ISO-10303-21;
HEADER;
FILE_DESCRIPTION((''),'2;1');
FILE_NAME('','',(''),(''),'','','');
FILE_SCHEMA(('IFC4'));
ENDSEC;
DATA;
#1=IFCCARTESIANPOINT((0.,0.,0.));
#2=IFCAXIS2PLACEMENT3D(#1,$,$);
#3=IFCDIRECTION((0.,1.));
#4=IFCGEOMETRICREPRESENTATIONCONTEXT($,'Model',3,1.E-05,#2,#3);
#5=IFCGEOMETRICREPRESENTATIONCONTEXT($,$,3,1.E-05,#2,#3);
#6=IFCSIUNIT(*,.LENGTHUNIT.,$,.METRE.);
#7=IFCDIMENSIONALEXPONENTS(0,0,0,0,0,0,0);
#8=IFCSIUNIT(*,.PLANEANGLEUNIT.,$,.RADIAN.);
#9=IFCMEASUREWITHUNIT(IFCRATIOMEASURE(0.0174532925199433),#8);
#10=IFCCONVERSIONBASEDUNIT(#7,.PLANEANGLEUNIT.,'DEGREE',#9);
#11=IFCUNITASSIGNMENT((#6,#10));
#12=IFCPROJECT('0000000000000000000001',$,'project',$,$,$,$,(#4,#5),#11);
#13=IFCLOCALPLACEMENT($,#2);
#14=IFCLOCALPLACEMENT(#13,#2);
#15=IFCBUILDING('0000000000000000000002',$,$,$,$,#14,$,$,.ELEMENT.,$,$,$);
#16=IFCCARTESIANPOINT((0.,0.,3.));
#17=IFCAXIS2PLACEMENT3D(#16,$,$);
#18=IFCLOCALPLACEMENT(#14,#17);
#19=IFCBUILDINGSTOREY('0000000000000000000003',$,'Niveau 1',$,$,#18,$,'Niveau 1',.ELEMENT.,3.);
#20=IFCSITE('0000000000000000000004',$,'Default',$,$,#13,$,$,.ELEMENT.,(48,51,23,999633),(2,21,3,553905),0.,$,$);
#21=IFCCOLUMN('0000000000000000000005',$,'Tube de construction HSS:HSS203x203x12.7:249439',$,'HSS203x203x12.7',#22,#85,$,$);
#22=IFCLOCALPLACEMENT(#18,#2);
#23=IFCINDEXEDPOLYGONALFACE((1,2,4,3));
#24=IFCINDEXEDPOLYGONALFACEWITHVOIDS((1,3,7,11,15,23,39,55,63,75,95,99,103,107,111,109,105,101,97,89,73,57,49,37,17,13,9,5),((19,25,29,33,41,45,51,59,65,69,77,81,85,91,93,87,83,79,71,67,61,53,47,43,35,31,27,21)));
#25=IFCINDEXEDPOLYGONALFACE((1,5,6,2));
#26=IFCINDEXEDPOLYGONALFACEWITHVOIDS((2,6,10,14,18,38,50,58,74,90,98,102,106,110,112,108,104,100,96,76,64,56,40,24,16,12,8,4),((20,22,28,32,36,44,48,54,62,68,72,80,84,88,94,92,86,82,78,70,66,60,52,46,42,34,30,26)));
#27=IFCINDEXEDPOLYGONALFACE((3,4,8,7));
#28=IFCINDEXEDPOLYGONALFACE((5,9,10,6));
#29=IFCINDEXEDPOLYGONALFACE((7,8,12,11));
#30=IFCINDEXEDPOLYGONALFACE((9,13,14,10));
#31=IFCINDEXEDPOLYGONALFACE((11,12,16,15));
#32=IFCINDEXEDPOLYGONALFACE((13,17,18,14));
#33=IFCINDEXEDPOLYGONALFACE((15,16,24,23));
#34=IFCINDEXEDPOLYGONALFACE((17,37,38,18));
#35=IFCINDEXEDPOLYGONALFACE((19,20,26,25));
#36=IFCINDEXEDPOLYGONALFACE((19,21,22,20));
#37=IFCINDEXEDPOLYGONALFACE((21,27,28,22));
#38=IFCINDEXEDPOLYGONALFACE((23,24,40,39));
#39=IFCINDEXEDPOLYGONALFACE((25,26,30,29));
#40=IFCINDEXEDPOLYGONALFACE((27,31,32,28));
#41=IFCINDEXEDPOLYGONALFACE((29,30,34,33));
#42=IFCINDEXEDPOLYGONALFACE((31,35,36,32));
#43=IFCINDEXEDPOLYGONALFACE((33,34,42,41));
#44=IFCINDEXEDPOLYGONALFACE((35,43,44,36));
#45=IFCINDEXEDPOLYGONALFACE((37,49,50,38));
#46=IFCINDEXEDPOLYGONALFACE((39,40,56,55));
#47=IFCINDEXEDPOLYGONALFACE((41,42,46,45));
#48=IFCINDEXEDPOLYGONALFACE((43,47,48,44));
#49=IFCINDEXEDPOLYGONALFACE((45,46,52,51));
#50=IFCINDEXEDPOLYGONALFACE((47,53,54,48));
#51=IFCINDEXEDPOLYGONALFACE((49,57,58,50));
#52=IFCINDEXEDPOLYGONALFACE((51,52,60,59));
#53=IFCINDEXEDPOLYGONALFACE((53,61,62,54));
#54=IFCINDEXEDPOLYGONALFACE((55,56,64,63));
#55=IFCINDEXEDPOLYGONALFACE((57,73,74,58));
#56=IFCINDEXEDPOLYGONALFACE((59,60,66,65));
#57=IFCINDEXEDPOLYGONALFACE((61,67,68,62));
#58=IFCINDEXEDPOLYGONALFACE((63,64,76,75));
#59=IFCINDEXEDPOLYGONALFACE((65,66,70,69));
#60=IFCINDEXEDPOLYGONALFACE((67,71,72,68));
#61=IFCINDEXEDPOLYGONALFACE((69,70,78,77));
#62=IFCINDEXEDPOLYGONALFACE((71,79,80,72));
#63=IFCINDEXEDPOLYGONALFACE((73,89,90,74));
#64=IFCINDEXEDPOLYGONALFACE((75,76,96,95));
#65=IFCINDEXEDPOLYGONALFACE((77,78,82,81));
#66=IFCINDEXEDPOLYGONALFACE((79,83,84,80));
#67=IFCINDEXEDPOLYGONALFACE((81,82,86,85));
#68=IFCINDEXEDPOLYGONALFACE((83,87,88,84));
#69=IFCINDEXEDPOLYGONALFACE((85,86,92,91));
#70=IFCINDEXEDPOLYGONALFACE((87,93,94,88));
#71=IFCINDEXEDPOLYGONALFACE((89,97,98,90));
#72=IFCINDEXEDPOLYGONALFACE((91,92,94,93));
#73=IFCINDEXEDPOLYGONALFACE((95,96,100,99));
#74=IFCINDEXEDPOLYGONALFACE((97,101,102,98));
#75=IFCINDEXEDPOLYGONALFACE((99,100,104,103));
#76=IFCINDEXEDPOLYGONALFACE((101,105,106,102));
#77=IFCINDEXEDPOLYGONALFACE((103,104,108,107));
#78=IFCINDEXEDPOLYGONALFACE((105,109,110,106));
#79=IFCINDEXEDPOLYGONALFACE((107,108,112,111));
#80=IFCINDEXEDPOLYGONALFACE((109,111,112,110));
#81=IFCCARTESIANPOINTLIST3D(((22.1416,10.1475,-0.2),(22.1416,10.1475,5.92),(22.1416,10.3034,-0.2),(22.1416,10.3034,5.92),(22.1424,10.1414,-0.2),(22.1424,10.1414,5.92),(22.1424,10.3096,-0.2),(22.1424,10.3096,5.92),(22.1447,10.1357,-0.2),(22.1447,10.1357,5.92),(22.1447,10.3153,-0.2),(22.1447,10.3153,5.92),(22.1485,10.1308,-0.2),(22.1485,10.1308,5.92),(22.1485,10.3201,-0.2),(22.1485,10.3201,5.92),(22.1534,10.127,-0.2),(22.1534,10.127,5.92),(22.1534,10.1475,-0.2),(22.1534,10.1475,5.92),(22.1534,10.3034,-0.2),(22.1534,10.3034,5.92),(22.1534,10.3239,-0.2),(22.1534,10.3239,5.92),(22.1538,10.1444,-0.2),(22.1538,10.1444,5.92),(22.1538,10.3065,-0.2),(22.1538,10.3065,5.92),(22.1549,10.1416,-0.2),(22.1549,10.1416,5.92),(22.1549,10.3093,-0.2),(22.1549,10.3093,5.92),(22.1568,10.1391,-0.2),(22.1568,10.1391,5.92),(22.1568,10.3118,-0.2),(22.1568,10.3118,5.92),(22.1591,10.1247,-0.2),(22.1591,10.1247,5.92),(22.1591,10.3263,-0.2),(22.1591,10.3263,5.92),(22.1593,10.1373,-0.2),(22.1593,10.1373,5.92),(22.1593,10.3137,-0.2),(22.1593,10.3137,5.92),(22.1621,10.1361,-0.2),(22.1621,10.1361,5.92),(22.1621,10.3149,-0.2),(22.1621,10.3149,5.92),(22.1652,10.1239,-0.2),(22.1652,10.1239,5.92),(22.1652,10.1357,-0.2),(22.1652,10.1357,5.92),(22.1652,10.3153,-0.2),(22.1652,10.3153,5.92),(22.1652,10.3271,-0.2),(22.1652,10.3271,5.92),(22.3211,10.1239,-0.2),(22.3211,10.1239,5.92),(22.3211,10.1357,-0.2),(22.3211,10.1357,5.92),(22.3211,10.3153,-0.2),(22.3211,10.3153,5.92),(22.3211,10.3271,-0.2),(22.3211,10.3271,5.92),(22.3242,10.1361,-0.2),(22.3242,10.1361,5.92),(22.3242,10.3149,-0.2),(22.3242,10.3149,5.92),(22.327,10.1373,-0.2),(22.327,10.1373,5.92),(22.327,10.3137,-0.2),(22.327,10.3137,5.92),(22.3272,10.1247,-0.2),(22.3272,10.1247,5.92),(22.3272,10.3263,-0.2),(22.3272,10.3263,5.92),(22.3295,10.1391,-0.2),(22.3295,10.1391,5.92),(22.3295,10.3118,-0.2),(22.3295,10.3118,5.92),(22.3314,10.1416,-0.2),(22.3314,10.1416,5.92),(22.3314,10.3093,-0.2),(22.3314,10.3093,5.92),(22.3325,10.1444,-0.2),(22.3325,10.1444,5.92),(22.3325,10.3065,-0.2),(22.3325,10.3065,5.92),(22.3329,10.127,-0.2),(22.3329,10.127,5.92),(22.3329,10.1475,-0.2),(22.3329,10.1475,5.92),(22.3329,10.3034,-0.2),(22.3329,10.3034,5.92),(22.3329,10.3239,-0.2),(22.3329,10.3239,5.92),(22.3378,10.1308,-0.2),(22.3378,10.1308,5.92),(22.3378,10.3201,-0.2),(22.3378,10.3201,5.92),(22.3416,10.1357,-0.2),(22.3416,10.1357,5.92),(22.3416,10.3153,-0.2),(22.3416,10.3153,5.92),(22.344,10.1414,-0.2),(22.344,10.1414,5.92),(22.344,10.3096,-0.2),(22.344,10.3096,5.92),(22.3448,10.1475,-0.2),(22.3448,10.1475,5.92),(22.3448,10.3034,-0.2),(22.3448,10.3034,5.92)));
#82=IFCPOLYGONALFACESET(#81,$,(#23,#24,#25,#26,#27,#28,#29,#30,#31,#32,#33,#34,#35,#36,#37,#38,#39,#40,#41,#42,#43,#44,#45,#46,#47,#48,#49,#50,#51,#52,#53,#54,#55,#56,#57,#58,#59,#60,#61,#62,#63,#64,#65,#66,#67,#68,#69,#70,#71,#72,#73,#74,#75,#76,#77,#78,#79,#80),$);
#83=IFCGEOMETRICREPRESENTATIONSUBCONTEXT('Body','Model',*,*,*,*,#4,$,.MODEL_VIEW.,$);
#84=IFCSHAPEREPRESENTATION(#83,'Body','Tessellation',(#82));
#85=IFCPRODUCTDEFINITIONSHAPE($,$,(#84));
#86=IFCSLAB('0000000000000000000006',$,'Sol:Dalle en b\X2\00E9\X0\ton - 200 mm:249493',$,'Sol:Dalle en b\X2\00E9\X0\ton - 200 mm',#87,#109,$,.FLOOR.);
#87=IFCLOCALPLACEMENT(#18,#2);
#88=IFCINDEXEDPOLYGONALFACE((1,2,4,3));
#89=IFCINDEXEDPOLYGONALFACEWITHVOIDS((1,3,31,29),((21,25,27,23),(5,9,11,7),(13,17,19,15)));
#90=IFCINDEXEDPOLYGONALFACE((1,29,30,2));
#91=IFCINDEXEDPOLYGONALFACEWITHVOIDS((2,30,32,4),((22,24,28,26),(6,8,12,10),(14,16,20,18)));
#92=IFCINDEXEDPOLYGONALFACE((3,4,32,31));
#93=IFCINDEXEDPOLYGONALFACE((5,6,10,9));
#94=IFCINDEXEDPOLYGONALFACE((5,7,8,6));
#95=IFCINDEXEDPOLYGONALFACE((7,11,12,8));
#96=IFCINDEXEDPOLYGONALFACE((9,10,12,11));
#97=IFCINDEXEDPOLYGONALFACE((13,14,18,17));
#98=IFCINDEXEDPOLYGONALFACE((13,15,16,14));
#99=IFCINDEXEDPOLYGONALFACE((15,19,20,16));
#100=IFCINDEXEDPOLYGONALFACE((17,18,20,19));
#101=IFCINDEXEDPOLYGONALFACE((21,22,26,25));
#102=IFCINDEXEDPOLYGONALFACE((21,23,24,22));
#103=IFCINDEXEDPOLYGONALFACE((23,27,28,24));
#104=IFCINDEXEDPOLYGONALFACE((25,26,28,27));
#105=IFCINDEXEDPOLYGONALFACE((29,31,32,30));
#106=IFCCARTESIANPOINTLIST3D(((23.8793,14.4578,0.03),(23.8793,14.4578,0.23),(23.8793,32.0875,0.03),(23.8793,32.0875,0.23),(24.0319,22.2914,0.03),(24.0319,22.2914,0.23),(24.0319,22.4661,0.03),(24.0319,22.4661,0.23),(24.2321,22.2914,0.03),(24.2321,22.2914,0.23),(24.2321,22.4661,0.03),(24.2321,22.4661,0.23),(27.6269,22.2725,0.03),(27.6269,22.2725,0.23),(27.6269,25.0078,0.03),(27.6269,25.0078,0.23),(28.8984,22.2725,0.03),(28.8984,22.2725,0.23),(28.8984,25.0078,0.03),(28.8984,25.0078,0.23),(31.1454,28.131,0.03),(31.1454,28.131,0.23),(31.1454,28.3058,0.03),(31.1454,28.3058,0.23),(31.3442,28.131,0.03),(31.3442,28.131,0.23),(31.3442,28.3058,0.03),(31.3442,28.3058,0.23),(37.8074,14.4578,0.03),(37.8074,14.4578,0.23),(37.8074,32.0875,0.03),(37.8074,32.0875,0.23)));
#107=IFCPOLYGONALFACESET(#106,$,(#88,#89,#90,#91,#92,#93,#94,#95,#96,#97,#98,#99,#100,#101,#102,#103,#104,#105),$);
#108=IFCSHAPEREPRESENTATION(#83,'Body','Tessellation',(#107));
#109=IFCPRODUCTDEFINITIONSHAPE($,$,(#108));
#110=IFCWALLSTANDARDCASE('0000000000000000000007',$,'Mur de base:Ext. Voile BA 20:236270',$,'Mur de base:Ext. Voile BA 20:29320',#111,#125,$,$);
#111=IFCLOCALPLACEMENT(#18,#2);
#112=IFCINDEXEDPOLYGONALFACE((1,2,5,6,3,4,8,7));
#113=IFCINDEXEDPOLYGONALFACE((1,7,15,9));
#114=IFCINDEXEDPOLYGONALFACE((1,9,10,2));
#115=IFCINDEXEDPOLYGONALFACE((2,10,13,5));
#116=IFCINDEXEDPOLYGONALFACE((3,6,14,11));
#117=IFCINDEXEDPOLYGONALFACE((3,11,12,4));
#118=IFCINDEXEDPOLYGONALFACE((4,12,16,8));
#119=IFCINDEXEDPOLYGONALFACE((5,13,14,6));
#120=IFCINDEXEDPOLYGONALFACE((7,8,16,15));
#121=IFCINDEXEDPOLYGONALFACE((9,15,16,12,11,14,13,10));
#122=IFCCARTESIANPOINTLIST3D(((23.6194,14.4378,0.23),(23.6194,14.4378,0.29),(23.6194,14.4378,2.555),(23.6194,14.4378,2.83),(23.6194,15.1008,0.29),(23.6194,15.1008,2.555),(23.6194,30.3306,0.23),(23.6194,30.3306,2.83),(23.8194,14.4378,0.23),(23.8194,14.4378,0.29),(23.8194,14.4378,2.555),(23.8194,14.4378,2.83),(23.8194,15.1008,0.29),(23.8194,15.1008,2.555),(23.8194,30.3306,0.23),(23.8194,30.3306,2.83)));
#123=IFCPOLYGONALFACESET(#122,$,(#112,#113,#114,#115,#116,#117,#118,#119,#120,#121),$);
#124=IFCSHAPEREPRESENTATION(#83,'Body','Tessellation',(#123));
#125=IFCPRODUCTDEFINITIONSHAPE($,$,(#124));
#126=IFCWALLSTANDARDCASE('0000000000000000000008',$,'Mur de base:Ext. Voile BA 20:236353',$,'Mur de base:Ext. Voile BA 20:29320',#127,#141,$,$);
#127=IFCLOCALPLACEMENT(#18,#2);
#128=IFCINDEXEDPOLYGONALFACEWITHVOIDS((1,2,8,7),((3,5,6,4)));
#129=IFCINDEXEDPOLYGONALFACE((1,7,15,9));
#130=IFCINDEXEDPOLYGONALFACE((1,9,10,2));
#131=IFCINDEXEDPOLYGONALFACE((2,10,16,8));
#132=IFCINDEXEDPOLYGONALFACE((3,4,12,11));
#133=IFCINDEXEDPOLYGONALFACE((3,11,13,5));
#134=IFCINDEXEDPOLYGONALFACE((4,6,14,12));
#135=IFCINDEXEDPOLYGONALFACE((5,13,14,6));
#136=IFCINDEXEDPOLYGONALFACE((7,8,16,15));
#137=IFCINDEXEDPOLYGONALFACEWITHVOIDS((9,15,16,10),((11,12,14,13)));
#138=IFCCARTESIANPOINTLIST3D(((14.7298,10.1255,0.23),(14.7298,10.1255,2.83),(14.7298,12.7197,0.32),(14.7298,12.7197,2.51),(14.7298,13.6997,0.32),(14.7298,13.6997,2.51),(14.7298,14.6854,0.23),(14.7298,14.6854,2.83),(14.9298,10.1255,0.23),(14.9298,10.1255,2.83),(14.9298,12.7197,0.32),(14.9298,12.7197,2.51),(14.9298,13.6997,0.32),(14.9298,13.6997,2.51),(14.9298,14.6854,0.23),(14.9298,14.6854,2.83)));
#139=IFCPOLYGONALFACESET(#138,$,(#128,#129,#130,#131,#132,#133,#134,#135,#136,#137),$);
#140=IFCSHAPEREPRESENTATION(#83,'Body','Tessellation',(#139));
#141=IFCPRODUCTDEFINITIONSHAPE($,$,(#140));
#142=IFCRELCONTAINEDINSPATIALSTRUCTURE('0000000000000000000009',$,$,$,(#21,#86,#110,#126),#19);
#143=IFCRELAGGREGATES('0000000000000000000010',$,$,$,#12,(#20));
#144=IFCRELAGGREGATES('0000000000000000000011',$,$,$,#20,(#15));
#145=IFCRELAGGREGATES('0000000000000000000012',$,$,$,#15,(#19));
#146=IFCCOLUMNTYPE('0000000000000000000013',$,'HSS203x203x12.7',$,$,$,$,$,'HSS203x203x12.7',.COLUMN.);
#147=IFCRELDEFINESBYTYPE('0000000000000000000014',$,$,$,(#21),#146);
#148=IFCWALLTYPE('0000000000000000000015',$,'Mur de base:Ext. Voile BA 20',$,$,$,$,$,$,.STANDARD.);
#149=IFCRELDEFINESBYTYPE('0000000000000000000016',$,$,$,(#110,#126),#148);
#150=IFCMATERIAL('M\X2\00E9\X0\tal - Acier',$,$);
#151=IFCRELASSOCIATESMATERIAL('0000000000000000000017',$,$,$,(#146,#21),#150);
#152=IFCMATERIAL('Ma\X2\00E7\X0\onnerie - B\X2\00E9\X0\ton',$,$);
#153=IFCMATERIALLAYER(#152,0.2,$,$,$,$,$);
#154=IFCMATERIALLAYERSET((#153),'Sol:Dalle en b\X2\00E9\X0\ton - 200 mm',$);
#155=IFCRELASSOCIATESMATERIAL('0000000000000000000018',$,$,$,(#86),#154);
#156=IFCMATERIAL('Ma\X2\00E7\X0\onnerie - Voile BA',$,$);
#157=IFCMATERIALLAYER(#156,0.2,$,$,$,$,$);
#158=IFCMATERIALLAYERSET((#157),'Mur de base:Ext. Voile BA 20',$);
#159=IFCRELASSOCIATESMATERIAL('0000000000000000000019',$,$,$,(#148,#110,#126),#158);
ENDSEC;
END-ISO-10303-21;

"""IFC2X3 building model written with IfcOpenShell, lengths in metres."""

from ifc_helpers import new_model, entity, si_unit, converted_unit, direction, frame, frame_2d, origin, origin_2d_with_axis, place, context, subcontext, project, spatial, polyline, circle_curve, parameter, trimmed, segment, composite_curve, rectangle, outline, extrude, source, transform, mapped, material, layer, layer_set, layer_usage, type_object, type_shapes, element, save


model = new_model("IFC2X3")

# Units and contexts
model_context = context("Model", 3, precision=1e-05, world=origin(), true_north=direction((0.0, 1.0)))
context_of_model = context(None, 3, precision=1e-05, world=origin(), true_north=direction((0.0, 1.0)))
body_context = subcontext(model_context, "Body", "Model", "MODEL_VIEW")
ifc_project = project(units=[si_unit("LENGTHUNIT", "METRE"), converted_unit("PLANEANGLEUNIT", "DEGREE", entity("IfcRatioMeasure", 0.0174532925199433), si_unit("PLANEANGLEUNIT", "RADIAN"), dimensions=[0, 0, 0, 0, 0, 0, 0])], contexts=[model_context, context_of_model])

# Site, building, storey
site_placement = place(None, origin())
site = spatial("IfcSite", under=ifc_project, at=site_placement, Name="Default", CompositionType="ELEMENT", RefLatitude=(48, 51, 23, 999633), RefLongitude=(2, 21, 3, 553905), RefElevation=0.0)
building_placement = place(site_placement, origin())
building = spatial("IfcBuilding", under=site, at=building_placement, CompositionType="ELEMENT")
storey_placement = place(building_placement, frame((0.0, 0.0, 3.0)))
storey = spatial("IfcBuildingStorey", under=building, at=storey_placement, Name="Niveau 1", LongName="Niveau 1", CompositionType="ELEMENT", Elevation=3.0)

# Column
ifc_material_1 = material(Name="Métal - Acier")
column_type = type_object("IfcColumnType", Name="HSS203x203x12.7", ElementType="HSS203x203x12.7", PredefinedType="COLUMN", material=ifc_material_1)
shared_shape = source(origin(), body_context, "Body", "SweptSolid", [
    extrude(outline(composite_curve([segment(polyline([(-0.078, -0.1016), (0.078, -0.1016)]), True, "CONTINUOUS"), segment(trimmed(circle_curve(frame_2d((0.078, -0.078), x_axis=(-1.0, 0.0)), 0.0236), [parameter(90.0)], [parameter(180.0)], True, "PARAMETER"), True, "CONTINUOUS"), segment(polyline([(0.1016, -0.078), (0.1016, 0.078)]), True, "CONTINUOUS"), segment(trimmed(circle_curve(frame_2d((0.078, 0.078), x_axis=(-1.0, 0.0)), 0.0236), [parameter(180.0)], [parameter(270.0)], True, "PARAMETER"), True, "CONTINUOUS"), segment(polyline([(0.078, 0.1016), (-0.078, 0.1016)]), True, "CONTINUOUS"), segment(trimmed(circle_curve(frame_2d((-0.078, 0.078), x_axis=(-1.0, 0.0)), 0.0236), [parameter(270.0)], [parameter(360.0)], True, "PARAMETER"), True, "CONTINUOUS"), segment(polyline([(-0.1016, 0.078), (-0.1016, -0.078)]), True, "CONTINUOUS"), segment(trimmed(circle_curve(frame_2d((-0.078, -0.078), x_axis=(-1.0, 0.0)), 0.0236), [parameter(360.0)], [parameter(90.0)], True, "PARAMETER"), True, "CONTINUOUS")], self_intersect=False), holes=[composite_curve([segment(trimmed(circle_curve(frame_2d((-0.078, -0.078), x_axis=(-1.0, 0.0)), 0.0118), [parameter(0.0)], [parameter(90.0)], True, "PARAMETER"), False, "CONTINUOUS"), segment(polyline([(-0.0898, -0.078), (-0.0898, 0.078)]), True, "CONTINUOUS"), segment(trimmed(circle_curve(frame_2d((-0.078, 0.078), x_axis=(-1.0, 0.0)), 0.0118), [parameter(270.0)], [parameter(360.0)], True, "PARAMETER"), False, "CONTINUOUS"), segment(polyline([(-0.078, 0.0898), (0.078, 0.0898)]), True, "CONTINUOUS"), segment(trimmed(circle_curve(frame_2d((0.078, 0.078), x_axis=(-1.0, 0.0)), 0.0118), [parameter(180.0)], [parameter(270.0)], True, "PARAMETER"), False, "CONTINUOUS"), segment(polyline([(0.0898, 0.078), (0.0898, -0.078)]), True, "CONTINUOUS"), segment(trimmed(circle_curve(frame_2d((0.078, -0.078), x_axis=(-1.0, 0.0)), 0.0118), [parameter(90.0)], [parameter(180.0)], True, "PARAMETER"), False, "CONTINUOUS"), segment(polyline([(0.078, -0.0898), (-0.078, -0.0898)]), True, "CONTINUOUS")], self_intersect=False)]), frame((0.0, 0.0, 2.8), z_axis=(0.0, 0.0, 1.0), x_axis=(-1.0, 0.0, 0.0)), (0.0, 0.0, 1.0), 6.12),
])
type_shapes(column_type, [shared_shape])
for number, where, name in (
    (1, (22.2432, 10.2255, -3.0), "Tube de construction HSS:HSS203x203x12.7:249439"),
):
    element("IfcColumn", number, at=place(storey_placement, frame(where)), inside=storey, type_object=column_type, material=ifc_material_1, Name=name, ObjectType="HSS203x203x12.7", context=body_context, shape_type="MappedRepresentation", body=[
        mapped(shared_shape, transform((0.0, 0.0, 0.0), scale=1.0)),
    ])

# Slab, openings
ifc_material_2 = material(Name="Maçonnerie - Béton")
ifc_layer_1 = layer(ifc_material_2, 0.2)
ifc_layer_set_1 = layer_set([ifc_layer_1], Name="Sol:Dalle en béton - 200 mm")
ifc_layer_usage_1 = layer_usage(ifc_layer_set_1, "AXIS3", "POSITIVE", 0.0)
slab_placement = place(storey_placement, frame((23.8793, 14.4578, 0.03)))
slab = element("IfcSlab", 2, at=slab_placement, inside=storey, material=ifc_layer_usage_1, Name="Sol:Dalle en béton - 200 mm:249493", ObjectType="Sol:Dalle en béton - 200 mm", PredefinedType="FLOOR", context=body_context, shape_type="SweptSolid", body=[
    extrude(rectangle(XDim=13.9281, YDim=17.6297, at=origin_2d_with_axis()), frame((6.964, 8.8148, 0.2), z_axis=(0.0, 0.0, -1.0), x_axis=(-1.0, 0.0, 0.0)), (0.0, 0.0, 1.0), 0.2),
])
opening_1_placement = place(slab_placement, frame((0.2527, 7.9209, 0.2)))
element("IfcOpeningElement", 3, at=opening_1_placement, cuts=slab, ObjectType="Opening", context=body_context, shape_type="SweptSolid", body=[
    extrude(rectangle(XDim=0.2001, YDim=0.1747, at=origin_2d_with_axis()), frame((0.0, 0.0, 0.0), z_axis=(0.0, 0.0, -1.0), x_axis=(-1.0, 0.0, 0.0)), (0.0, 0.0, 1.0), 0.2),
])
opening_2_placement = place(slab_placement, frame((7.3655, 13.7606, 0.2)))
element("IfcOpeningElement", 4, at=opening_2_placement, cuts=slab, ObjectType="Opening", context=body_context, shape_type="SweptSolid", body=[
    extrude(rectangle(XDim=0.1988, YDim=0.1747, at=origin_2d_with_axis()), frame((0.0, 0.0, 0.0), z_axis=(0.0, 0.0, -1.0), x_axis=(-1.0, 0.0, 0.0)), (0.0, 0.0, 1.0), 0.2),
])
opening_3_placement = place(slab_placement, frame((4.3834, 9.1823, 0.2)))
element("IfcOpeningElement", 5, at=opening_3_placement, cuts=slab, ObjectType="Opening", context=body_context, shape_type="SweptSolid", body=[
    extrude(rectangle(XDim=1.2714, YDim=2.7353, at=origin_2d_with_axis()), frame((0.0, 0.0, 0.0), z_axis=(0.0, 0.0, -1.0), x_axis=(-1.0, 0.0, 0.0)), (0.0, 0.0, 1.0), 0.2),
])

# Walls, openings
ifc_material_3 = material(Name="Maçonnerie - Voile BA")
ifc_layer_2 = layer(ifc_material_3, 0.2)
ifc_layer_set_2 = layer_set([ifc_layer_2], Name="Mur de base:Ext. Voile BA 20")
ifc_layer_usage_2 = layer_usage(ifc_layer_set_2, "AXIS2", "NEGATIVE", 0.1)
wall_type_1 = type_object("IfcWallType", Name="Mur de base:Ext. Voile BA 20", PredefinedType="STANDARD", material=ifc_layer_set_2)
wall_1_placement = place(storey_placement, frame((23.7194, 14.4378, 0.23), z_axis=(0.0, 0.0, 1.0), x_axis=(0.0, 1.0, 0.0)))
wall_1 = element("IfcWallStandardCase", 6, at=wall_1_placement, inside=storey, type_object=wall_type_1, material=ifc_layer_usage_2, Name="Mur de base:Ext. Voile BA 20:236270", ObjectType="Mur de base:Ext. Voile BA 20:29320", context=body_context, shape_type="SweptSolid", body=[
    extrude(rectangle(XDim=15.8928, YDim=0.2, at=frame_2d((7.9464, 0.0), x_axis=(-1.0, 0.0))), origin(), (0.0, 0.0, 1.0), 2.6),
])
opening_4_placement = place(wall_1_placement, origin())
element("IfcOpeningElement", 7, at=opening_4_placement, cuts=wall_1, ObjectType="Opening", context=body_context, shape_type="SweptSolid", body=[
    extrude(rectangle(XDim=2.265, YDim=1.0, at=origin_2d_with_axis()), frame((0.163, -0.1, 1.1925), z_axis=(0.0, 1.0, 0.0), x_axis=(0.0, 0.0, -1.0)), (0.0, 0.0, 1.0), 0.2),
])
ifc_layer_usage_3 = layer_usage(ifc_layer_set_2, "AXIS2", "NEGATIVE", 0.1)
wall_2_placement = place(storey_placement, frame((14.8298, 10.1255, 0.23), z_axis=(0.0, 0.0, 1.0), x_axis=(0.0, 1.0, 0.0)))
wall_2 = element("IfcWallStandardCase", 8, at=wall_2_placement, inside=storey, type_object=wall_type_1, material=ifc_layer_usage_3, Name="Mur de base:Ext. Voile BA 20:236353", ObjectType="Mur de base:Ext. Voile BA 20:29320", context=body_context, shape_type="SweptSolid", body=[
    extrude(rectangle(XDim=4.5599, YDim=0.2, at=frame_2d((2.28, 0.0), x_axis=(-1.0, 0.0))), origin(), (0.0, 0.0, 1.0), 2.6),
])
opening_5_placement = place(wall_2_placement, origin())
element("IfcOpeningElement", 9, at=opening_5_placement, cuts=wall_2, ObjectType="Opening", context=body_context, shape_type="SweptSolid", body=[
    extrude(rectangle(XDim=2.19, YDim=0.98, at=frame_2d((0.0, 0.0), x_axis=(1.0, 0.0))), frame((3.0842, -0.1, 1.185), z_axis=(0.0, 1.0, 0.0), x_axis=(0.0, 0.0, -1.0)), (0.0, 0.0, 1.0), 0.2),
])

save(model, "model.ifc")
